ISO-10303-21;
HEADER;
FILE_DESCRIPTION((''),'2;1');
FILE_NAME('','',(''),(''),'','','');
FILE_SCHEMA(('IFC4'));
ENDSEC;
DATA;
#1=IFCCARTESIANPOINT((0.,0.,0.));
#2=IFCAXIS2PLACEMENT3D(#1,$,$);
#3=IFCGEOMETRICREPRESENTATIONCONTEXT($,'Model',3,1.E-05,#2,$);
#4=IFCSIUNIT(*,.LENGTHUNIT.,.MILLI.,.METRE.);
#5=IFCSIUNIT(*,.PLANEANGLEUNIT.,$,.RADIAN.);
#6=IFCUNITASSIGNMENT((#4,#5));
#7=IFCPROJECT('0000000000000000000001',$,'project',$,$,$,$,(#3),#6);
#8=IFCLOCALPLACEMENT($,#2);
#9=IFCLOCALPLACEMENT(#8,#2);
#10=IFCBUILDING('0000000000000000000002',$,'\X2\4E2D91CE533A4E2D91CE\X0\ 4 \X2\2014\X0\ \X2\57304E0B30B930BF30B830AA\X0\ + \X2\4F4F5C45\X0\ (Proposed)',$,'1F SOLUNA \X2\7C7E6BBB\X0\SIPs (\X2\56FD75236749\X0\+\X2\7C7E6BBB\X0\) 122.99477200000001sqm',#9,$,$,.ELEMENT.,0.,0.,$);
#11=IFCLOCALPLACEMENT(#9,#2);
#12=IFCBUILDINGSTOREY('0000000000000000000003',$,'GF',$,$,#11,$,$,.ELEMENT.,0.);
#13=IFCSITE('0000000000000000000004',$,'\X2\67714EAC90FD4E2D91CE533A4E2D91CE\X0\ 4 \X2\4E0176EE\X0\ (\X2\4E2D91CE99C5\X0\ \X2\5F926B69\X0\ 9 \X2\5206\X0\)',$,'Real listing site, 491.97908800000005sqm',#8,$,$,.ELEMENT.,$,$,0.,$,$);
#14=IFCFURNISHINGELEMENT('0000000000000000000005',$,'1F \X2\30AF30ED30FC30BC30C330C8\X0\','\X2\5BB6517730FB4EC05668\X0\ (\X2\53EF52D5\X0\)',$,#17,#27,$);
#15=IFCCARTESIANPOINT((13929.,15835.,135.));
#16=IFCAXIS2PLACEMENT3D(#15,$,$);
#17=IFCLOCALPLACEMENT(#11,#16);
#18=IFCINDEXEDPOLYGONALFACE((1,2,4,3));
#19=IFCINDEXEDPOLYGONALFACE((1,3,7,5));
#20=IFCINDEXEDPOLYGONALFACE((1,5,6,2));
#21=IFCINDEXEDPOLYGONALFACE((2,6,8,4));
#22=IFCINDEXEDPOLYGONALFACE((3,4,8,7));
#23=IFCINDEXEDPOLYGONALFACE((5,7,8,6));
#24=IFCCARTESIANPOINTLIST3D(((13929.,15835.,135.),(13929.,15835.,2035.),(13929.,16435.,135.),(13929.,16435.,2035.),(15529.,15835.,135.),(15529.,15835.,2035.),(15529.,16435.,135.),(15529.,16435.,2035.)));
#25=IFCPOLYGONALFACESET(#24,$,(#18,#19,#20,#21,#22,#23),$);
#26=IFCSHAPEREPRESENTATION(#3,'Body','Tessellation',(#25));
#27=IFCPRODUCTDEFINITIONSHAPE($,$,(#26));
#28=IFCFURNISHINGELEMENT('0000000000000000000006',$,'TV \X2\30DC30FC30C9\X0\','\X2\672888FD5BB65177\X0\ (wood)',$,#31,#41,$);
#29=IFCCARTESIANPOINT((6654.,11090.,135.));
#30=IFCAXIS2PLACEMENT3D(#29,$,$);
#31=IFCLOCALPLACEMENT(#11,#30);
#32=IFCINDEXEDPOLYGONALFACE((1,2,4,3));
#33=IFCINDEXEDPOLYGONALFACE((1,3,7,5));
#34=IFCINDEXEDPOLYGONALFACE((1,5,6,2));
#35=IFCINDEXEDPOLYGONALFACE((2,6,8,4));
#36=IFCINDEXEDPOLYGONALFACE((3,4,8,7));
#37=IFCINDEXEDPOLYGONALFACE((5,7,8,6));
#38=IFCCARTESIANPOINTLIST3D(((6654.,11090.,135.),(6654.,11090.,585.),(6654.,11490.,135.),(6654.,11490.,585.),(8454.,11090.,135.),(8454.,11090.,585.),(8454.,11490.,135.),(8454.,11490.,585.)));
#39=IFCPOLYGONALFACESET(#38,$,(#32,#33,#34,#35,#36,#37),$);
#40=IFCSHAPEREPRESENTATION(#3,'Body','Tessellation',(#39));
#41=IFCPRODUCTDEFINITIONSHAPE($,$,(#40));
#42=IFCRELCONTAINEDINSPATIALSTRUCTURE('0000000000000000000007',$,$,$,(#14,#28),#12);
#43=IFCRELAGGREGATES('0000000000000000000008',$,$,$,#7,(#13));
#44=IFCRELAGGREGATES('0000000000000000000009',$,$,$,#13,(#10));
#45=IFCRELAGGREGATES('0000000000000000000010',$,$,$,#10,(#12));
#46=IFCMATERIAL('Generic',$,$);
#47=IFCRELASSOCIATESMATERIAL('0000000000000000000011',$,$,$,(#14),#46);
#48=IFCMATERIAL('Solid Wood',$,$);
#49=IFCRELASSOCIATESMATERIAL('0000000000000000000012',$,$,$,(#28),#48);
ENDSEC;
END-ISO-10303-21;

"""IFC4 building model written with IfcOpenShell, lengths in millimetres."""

from ifc_helpers import new_model, si_unit, frame, frame_2d, origin, place, context, project, spatial, rectangle, extrude, material, element, save


model = new_model("IFC4")

# Units and contexts
model_context = context("Model", 3, precision=1e-05, world=origin())
ifc_project = project(units=[si_unit("LENGTHUNIT", "METRE", prefix="MILLI"), si_unit("PLANEANGLEUNIT", "RADIAN")], contexts=[model_context])

# Site, building, storey
site_placement = place(None, origin())
site = spatial("IfcSite", under=ifc_project, at=site_placement, Name="東京都中野区中野 4 丁目 (中野駅 徒歩 9 分)", ObjectType="Real listing site, 491.97908800000005sqm", CompositionType="ELEMENT", RefElevation=0.0)
building_placement = place(site_placement, origin())
building = spatial("IfcBuilding", under=site, at=building_placement, Name="中野区中野 4 — 地下スタジオ + 住居 (Proposed)", ObjectType="1F SOLUNA 籾殻SIPs (国産杉+籾殻) 122.99477200000001sqm", CompositionType="ELEMENT", ElevationOfRefHeight=0.0, ElevationOfTerrain=0.0)
storey_placement = place(building_placement, origin())
storey = spatial("IfcBuildingStorey", under=building, at=storey_placement, Name="GF", CompositionType="ELEMENT", Elevation=0.0)

# Shared definitions
ifc_material_1 = material(Name="Solid Wood")

# Shared definitions
ifc_material_2 = material(Name="Generic")

# Furnishing elements
furnishing_1_placement = place(storey_placement, frame((13929.0, 15835.0, 135.0)))
element("IfcFurnishingElement", 1, at=furnishing_1_placement, inside=storey, material=ifc_material_2, Name="1F クローゼット", Description="家具・什器 (可動)", context=model_context, shape_type="SweptSolid", body=[
    extrude(rectangle(XDim=1600.0, YDim=600.0, at=frame_2d((800.0, 300.0))), frame((13929.0, 15835.0, 135.0)), (0.0, 0.0, 1.0), 1900.0),
])
furnishing_2_placement = place(storey_placement, frame((6654.0, 11090.0, 135.0)))
element("IfcFurnishingElement", 2, at=furnishing_2_placement, inside=storey, material=ifc_material_1, Name="TV ボード", Description="木製家具 (wood)", context=model_context, shape_type="SweptSolid", body=[
    extrude(rectangle(XDim=1800.0, YDim=400.0, at=frame_2d((900.0, 200.0))), frame((6654.0, 11090.0, 135.0)), (0.0, 0.0, 1.0), 450.0),
])

save(model, "model.ifc")
